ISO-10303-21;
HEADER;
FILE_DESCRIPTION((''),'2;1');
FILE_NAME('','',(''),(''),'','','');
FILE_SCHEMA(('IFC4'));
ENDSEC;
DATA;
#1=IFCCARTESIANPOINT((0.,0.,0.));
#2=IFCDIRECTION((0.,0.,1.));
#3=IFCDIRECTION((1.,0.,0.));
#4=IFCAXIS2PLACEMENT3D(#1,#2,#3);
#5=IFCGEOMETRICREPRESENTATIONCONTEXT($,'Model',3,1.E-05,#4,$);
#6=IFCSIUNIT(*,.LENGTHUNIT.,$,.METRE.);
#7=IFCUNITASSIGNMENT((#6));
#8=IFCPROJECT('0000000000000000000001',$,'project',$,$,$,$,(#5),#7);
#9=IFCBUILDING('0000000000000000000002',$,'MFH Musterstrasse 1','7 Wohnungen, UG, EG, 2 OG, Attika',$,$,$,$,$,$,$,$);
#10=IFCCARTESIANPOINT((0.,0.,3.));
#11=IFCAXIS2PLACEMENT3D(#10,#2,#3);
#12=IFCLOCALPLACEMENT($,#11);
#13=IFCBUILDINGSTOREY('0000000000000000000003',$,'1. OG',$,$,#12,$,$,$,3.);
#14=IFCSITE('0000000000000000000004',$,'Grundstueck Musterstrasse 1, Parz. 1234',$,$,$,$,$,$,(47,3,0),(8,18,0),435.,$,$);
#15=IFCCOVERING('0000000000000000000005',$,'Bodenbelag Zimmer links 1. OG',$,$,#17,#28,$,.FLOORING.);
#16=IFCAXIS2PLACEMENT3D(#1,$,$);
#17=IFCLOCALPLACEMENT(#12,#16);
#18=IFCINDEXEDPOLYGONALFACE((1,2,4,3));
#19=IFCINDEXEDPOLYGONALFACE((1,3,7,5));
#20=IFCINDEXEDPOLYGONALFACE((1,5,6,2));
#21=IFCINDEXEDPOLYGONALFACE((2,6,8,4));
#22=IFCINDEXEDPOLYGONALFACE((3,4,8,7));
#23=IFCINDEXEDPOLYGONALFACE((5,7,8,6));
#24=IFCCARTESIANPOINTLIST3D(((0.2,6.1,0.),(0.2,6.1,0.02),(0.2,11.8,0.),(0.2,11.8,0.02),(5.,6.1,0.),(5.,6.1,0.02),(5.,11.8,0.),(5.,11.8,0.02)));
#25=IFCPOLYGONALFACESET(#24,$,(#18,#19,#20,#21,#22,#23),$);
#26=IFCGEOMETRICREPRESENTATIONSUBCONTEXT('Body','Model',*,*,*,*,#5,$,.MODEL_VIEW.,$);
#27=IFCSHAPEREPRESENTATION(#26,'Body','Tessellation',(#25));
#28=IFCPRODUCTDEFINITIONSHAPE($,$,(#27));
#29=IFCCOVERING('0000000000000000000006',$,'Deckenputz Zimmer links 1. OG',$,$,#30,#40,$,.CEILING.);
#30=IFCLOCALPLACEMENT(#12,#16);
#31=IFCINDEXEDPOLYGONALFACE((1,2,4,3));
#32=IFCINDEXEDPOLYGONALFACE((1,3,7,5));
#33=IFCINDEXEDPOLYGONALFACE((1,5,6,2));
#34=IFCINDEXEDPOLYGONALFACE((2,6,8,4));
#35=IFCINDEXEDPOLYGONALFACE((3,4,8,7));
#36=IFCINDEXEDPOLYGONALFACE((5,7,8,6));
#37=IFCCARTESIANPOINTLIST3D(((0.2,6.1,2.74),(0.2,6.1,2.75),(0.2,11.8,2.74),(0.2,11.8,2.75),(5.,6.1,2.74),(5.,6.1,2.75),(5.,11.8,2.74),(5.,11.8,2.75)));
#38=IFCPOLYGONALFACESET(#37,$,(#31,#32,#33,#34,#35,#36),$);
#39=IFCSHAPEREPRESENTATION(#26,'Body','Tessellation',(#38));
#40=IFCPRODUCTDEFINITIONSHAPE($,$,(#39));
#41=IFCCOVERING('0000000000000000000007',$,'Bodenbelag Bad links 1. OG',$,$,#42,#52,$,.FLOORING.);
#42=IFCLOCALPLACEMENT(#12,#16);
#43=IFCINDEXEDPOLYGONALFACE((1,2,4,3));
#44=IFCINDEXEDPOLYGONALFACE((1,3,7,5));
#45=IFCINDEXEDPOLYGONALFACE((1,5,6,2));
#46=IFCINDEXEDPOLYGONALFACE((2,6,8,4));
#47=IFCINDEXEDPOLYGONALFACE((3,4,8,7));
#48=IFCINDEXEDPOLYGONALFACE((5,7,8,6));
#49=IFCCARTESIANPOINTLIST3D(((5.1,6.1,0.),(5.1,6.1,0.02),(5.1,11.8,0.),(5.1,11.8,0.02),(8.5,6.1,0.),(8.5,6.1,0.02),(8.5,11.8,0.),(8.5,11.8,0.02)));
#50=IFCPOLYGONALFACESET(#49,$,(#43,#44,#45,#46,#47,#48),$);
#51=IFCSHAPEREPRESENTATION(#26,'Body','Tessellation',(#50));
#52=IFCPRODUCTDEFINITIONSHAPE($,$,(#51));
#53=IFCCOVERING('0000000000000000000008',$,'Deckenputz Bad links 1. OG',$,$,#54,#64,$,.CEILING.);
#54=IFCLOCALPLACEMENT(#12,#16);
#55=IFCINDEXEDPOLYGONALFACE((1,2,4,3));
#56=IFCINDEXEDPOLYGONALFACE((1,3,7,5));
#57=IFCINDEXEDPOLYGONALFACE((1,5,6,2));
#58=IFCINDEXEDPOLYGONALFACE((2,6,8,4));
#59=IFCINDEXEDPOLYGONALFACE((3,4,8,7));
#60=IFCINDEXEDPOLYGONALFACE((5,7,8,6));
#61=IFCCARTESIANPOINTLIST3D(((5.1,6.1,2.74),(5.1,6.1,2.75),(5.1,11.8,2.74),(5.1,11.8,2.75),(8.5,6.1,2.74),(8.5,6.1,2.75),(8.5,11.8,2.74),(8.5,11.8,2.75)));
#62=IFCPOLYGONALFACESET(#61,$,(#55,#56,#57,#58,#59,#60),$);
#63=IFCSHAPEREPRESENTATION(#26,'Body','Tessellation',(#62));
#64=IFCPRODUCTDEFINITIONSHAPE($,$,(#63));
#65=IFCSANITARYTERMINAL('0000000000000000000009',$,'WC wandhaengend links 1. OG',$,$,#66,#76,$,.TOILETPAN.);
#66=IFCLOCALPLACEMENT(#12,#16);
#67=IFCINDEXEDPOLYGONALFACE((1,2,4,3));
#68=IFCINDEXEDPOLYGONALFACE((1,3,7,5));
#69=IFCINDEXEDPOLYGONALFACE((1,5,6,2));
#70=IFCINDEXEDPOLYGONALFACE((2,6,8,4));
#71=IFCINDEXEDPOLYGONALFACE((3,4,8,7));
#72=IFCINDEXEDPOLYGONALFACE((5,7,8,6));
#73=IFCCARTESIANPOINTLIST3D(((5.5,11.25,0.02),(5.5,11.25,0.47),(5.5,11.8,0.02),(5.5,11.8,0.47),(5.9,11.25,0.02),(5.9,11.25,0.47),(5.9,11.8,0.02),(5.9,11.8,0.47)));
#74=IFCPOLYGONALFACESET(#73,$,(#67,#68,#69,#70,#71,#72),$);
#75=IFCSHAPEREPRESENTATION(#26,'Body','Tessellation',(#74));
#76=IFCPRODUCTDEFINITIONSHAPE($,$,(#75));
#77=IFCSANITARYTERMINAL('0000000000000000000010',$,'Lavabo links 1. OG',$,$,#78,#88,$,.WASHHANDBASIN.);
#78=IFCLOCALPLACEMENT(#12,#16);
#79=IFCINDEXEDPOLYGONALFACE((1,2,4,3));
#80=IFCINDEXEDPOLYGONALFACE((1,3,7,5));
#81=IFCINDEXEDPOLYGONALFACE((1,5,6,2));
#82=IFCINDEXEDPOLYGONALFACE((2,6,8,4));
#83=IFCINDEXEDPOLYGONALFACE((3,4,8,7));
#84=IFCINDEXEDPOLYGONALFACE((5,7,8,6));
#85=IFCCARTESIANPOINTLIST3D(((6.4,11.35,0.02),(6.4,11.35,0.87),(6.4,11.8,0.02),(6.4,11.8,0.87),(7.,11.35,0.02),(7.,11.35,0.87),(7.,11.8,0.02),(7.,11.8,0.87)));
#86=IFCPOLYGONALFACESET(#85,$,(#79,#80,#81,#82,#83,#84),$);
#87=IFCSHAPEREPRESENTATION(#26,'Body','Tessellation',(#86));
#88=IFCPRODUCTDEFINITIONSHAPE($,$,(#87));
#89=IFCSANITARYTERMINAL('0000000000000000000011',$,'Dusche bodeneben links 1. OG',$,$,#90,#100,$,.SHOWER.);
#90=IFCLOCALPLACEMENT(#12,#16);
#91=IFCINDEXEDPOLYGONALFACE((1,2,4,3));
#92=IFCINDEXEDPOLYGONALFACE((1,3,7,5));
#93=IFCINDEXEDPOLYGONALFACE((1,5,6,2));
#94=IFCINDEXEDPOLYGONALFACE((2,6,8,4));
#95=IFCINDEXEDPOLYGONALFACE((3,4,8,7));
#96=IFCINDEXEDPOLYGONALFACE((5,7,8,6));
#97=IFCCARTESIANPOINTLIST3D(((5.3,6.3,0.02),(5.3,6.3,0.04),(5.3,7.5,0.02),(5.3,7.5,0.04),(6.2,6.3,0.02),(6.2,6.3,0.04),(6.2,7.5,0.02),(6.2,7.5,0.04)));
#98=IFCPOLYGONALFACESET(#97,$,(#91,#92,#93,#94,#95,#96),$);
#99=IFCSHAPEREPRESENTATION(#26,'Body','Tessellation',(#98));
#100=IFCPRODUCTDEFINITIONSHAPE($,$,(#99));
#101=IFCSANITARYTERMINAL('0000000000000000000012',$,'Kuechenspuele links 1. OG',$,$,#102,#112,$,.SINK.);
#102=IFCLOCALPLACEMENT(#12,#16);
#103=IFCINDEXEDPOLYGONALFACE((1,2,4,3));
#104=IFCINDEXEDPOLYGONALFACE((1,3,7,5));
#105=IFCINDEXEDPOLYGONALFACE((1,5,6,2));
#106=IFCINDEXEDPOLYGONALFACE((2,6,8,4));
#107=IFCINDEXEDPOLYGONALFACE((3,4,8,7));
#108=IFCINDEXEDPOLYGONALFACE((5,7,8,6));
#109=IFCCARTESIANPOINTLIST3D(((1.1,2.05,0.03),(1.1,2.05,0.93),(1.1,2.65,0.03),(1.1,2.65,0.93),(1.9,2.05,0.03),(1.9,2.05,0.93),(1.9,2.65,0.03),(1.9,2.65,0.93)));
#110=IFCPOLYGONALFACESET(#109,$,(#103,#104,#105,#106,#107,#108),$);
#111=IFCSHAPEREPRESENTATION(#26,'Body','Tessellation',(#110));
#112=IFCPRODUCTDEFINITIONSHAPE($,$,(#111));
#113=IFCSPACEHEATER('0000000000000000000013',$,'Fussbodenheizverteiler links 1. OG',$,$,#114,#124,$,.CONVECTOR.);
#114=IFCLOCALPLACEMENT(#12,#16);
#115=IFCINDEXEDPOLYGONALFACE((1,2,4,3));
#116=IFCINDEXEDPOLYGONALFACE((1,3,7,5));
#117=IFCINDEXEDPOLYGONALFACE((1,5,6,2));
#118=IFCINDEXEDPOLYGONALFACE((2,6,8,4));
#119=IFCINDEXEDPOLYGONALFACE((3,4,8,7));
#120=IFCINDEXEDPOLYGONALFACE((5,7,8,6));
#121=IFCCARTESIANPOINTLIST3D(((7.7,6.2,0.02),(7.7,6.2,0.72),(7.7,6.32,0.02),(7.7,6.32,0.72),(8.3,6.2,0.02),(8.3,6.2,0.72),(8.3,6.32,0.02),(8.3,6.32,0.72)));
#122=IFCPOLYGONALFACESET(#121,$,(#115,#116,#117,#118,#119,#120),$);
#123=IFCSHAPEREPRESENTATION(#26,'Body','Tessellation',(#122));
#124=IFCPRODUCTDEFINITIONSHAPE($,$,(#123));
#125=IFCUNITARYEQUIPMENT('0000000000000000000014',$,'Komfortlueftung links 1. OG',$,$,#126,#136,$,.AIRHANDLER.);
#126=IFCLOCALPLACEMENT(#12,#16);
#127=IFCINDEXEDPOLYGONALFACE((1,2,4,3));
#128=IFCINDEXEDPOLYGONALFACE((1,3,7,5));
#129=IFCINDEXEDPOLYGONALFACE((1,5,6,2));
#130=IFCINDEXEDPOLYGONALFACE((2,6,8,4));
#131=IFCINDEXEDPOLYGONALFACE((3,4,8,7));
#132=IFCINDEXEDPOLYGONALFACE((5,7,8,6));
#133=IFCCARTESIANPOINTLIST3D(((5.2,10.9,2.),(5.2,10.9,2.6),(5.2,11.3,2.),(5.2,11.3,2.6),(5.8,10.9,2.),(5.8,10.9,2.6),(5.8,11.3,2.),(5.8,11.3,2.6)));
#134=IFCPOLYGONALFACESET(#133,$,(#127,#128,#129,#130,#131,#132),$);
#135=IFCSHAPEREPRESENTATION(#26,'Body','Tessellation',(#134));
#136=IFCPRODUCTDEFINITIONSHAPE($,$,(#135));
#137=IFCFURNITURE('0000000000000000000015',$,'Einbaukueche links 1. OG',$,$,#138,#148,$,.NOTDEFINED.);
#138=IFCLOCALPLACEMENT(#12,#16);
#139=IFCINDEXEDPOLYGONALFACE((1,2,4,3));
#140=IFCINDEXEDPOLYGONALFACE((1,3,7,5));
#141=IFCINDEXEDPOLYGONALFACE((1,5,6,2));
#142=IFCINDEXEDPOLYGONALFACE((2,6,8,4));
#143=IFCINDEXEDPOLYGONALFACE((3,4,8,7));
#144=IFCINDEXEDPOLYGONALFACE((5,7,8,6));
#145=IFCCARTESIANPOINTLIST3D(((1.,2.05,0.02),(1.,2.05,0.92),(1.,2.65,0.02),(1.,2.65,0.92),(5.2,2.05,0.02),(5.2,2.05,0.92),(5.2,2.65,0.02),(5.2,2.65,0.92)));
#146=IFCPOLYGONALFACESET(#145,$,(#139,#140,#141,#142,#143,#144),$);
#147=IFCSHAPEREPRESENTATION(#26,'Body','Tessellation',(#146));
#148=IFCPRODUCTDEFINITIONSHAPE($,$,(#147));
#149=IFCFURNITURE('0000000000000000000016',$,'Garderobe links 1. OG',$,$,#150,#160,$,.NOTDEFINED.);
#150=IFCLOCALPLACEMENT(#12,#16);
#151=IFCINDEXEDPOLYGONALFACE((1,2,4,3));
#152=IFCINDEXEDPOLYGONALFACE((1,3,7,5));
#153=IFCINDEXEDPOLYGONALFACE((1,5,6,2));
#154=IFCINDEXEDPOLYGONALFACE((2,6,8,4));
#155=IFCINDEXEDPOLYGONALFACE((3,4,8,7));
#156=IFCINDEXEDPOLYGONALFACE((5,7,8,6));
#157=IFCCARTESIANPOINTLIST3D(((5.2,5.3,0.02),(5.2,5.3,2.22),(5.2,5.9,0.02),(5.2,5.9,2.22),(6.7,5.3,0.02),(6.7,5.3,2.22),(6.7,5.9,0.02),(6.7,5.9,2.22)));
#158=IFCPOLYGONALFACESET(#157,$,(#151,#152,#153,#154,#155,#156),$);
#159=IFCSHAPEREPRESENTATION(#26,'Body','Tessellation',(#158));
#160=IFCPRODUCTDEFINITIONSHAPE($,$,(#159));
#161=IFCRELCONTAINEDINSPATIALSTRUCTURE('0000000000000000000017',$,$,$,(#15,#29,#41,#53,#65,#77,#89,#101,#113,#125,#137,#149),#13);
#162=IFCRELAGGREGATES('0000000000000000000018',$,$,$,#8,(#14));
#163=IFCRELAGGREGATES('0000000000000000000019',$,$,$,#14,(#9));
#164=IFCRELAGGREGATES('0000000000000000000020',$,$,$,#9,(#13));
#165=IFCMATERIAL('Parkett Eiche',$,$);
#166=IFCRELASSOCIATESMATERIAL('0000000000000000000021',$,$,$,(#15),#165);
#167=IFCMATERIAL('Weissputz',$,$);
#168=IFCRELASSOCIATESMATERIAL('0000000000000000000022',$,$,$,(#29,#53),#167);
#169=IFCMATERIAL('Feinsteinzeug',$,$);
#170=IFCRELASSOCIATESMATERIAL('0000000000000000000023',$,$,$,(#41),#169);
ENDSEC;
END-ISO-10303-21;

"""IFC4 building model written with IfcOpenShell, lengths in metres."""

from ifc_helpers import new_model, si_unit, frame, frame_2d, origin_with_axes, place, context, subcontext, project, spatial, rectangle, extrude, material, element, save


model = new_model("IFC4")

# Units and contexts
model_context = context("Model", 3, precision=1e-05, world=origin_with_axes())
body_context = subcontext(model_context, "Body", "Model", "MODEL_VIEW")
ifc_project = project(units=[si_unit("LENGTHUNIT", "METRE")], contexts=[model_context])

# Site, building, storey
site = spatial("IfcSite", under=ifc_project, Name="Grundstueck Musterstrasse 1, Parz. 1234", RefLatitude=(47, 3, 0), RefLongitude=(8, 18, 0), RefElevation=435.0)
building = spatial("IfcBuilding", under=site, Name="MFH Musterstrasse 1", Description="7 Wohnungen, UG, EG, 2 OG, Attika")
storey_placement = place(None, frame((0.0, 0.0, 3.0), z_axis=(0.0, 0.0, 1.0), x_axis=(1.0, 0.0, 0.0)))
storey = spatial("IfcBuildingStorey", under=building, at=storey_placement, Name="1. OG", Elevation=3.0)

# Coverings
ifc_material_1 = material(Name="Parkett Eiche")
covering_1_placement = place(storey_placement, frame((0.2, 6.1, 0.0), z_axis=(0.0, 0.0, 1.0), x_axis=(1.0, 0.0, 0.0)))
element("IfcCovering", 1, at=covering_1_placement, inside=storey, material=ifc_material_1, Name="Bodenbelag Zimmer links 1. OG", PredefinedType="FLOORING", context=body_context, shape_type="SweptSolid", body=[
    extrude(rectangle(XDim=4.8, YDim=5.7, at=frame_2d((2.4, 2.85))), origin_with_axes(), (0.0, 0.0, 1.0), 0.02),
])
ifc_material_2 = material(Name="Weissputz")
covering_2_placement = place(storey_placement, frame((0.2, 6.1, 2.74), z_axis=(0.0, 0.0, 1.0), x_axis=(1.0, 0.0, 0.0)))
element("IfcCovering", 2, at=covering_2_placement, inside=storey, material=ifc_material_2, Name="Deckenputz Zimmer links 1. OG", PredefinedType="CEILING", context=body_context, shape_type="SweptSolid", body=[
    extrude(rectangle(XDim=4.8, YDim=5.7, at=frame_2d((2.4, 2.85))), origin_with_axes(), (0.0, 0.0, 1.0), 0.01),
])
ifc_material_3 = material(Name="Feinsteinzeug")
covering_3_placement = place(storey_placement, frame((5.1, 6.1, 0.0), z_axis=(0.0, 0.0, 1.0), x_axis=(1.0, 0.0, 0.0)))
element("IfcCovering", 3, at=covering_3_placement, inside=storey, material=ifc_material_3, Name="Bodenbelag Bad links 1. OG", PredefinedType="FLOORING", context=body_context, shape_type="SweptSolid", body=[
    extrude(rectangle(XDim=3.4, YDim=5.7, at=frame_2d((1.7, 2.85))), origin_with_axes(), (0.0, 0.0, 1.0), 0.02),
])
covering_4_placement = place(storey_placement, frame((5.1, 6.1, 2.74), z_axis=(0.0, 0.0, 1.0), x_axis=(1.0, 0.0, 0.0)))
element("IfcCovering", 4, at=covering_4_placement, inside=storey, material=ifc_material_2, Name="Deckenputz Bad links 1. OG", PredefinedType="CEILING", context=body_context, shape_type="SweptSolid", body=[
    extrude(rectangle(XDim=3.4, YDim=5.7, at=frame_2d((1.7, 2.85))), origin_with_axes(), (0.0, 0.0, 1.0), 0.01),
])

# Sanitary terminals
sanitary_terminal_1_placement = place(storey_placement, frame((5.5, 11.25, 0.02), z_axis=(0.0, 0.0, 1.0), x_axis=(1.0, 0.0, 0.0)))
element("IfcSanitaryTerminal", 5, at=sanitary_terminal_1_placement, inside=storey, Name="WC wandhaengend links 1. OG", PredefinedType="TOILETPAN", context=body_context, shape_type="SweptSolid", body=[
    extrude(rectangle(XDim=0.4, YDim=0.55, at=frame_2d((0.2, 0.275))), origin_with_axes(), (0.0, 0.0, 1.0), 0.45),
])
sanitary_terminal_2_placement = place(storey_placement, frame((6.4, 11.35, 0.02), z_axis=(0.0, 0.0, 1.0), x_axis=(1.0, 0.0, 0.0)))
element("IfcSanitaryTerminal", 6, at=sanitary_terminal_2_placement, inside=storey, Name="Lavabo links 1. OG", PredefinedType="WASHHANDBASIN", context=body_context, shape_type="SweptSolid", body=[
    extrude(rectangle(XDim=0.6, YDim=0.45, at=frame_2d((0.3, 0.225))), origin_with_axes(), (0.0, 0.0, 1.0), 0.85),
])
sanitary_terminal_3_placement = place(storey_placement, frame((5.3, 6.3, 0.02), z_axis=(0.0, 0.0, 1.0), x_axis=(1.0, 0.0, 0.0)))
element("IfcSanitaryTerminal", 7, at=sanitary_terminal_3_placement, inside=storey, Name="Dusche bodeneben links 1. OG", PredefinedType="SHOWER", context=body_context, shape_type="SweptSolid", body=[
    extrude(rectangle(XDim=0.9, YDim=1.2, at=frame_2d((0.45, 0.6))), origin_with_axes(), (0.0, 0.0, 1.0), 0.02),
])
sanitary_terminal_4_placement = place(storey_placement, frame((1.1, 2.05, 0.03), z_axis=(0.0, 0.0, 1.0), x_axis=(1.0, 0.0, 0.0)))
element("IfcSanitaryTerminal", 8, at=sanitary_terminal_4_placement, inside=storey, Name="Kuechenspuele links 1. OG", PredefinedType="SINK", context=body_context, shape_type="SweptSolid", body=[
    extrude(rectangle(XDim=0.8, YDim=0.6, at=frame_2d((0.4, 0.3))), origin_with_axes(), (0.0, 0.0, 1.0), 0.9),
])

# Space heater
space_heater_placement = place(storey_placement, frame((7.7, 6.2, 0.02), z_axis=(0.0, 0.0, 1.0), x_axis=(1.0, 0.0, 0.0)))
element("IfcSpaceHeater", 9, at=space_heater_placement, inside=storey, Name="Fussbodenheizverteiler links 1. OG", PredefinedType="CONVECTOR", context=body_context, shape_type="SweptSolid", body=[
    extrude(rectangle(XDim=0.6, YDim=0.12, at=frame_2d((0.3, 0.06))), origin_with_axes(), (0.0, 0.0, 1.0), 0.7),
])

# Unitary equipment
unitary_equipment_placement = place(storey_placement, frame((5.2, 10.9, 2.0), z_axis=(0.0, 0.0, 1.0), x_axis=(1.0, 0.0, 0.0)))
element("IfcUnitaryEquipment", 10, at=unitary_equipment_placement, inside=storey, Name="Komfortlueftung links 1. OG", PredefinedType="AIRHANDLER", context=body_context, shape_type="SweptSolid", body=[
    extrude(rectangle(XDim=0.6, YDim=0.4, at=frame_2d((0.3, 0.2))), origin_with_axes(), (0.0, 0.0, 1.0), 0.6),
])

# Furniture
furniture_1_placement = place(storey_placement, frame((1.0, 2.05, 0.02), z_axis=(0.0, 0.0, 1.0), x_axis=(1.0, 0.0, 0.0)))
element("IfcFurniture", 11, at=furniture_1_placement, inside=storey, Name="Einbaukueche links 1. OG", PredefinedType="NOTDEFINED", context=body_context, shape_type="SweptSolid", body=[
    extrude(rectangle(XDim=4.2, YDim=0.6, at=frame_2d((2.1, 0.3))), origin_with_axes(), (0.0, 0.0, 1.0), 0.9),
])
furniture_2_placement = place(storey_placement, frame((5.2, 5.3, 0.02), z_axis=(0.0, 0.0, 1.0), x_axis=(1.0, 0.0, 0.0)))
element("IfcFurniture", 12, at=furniture_2_placement, inside=storey, Name="Garderobe links 1. OG", PredefinedType="NOTDEFINED", context=body_context, shape_type="SweptSolid", body=[
    extrude(rectangle(XDim=1.5, YDim=0.6, at=frame_2d((0.75, 0.3))), origin_with_axes(), (0.0, 0.0, 1.0), 2.2),
])

save(model, "model.ifc")
